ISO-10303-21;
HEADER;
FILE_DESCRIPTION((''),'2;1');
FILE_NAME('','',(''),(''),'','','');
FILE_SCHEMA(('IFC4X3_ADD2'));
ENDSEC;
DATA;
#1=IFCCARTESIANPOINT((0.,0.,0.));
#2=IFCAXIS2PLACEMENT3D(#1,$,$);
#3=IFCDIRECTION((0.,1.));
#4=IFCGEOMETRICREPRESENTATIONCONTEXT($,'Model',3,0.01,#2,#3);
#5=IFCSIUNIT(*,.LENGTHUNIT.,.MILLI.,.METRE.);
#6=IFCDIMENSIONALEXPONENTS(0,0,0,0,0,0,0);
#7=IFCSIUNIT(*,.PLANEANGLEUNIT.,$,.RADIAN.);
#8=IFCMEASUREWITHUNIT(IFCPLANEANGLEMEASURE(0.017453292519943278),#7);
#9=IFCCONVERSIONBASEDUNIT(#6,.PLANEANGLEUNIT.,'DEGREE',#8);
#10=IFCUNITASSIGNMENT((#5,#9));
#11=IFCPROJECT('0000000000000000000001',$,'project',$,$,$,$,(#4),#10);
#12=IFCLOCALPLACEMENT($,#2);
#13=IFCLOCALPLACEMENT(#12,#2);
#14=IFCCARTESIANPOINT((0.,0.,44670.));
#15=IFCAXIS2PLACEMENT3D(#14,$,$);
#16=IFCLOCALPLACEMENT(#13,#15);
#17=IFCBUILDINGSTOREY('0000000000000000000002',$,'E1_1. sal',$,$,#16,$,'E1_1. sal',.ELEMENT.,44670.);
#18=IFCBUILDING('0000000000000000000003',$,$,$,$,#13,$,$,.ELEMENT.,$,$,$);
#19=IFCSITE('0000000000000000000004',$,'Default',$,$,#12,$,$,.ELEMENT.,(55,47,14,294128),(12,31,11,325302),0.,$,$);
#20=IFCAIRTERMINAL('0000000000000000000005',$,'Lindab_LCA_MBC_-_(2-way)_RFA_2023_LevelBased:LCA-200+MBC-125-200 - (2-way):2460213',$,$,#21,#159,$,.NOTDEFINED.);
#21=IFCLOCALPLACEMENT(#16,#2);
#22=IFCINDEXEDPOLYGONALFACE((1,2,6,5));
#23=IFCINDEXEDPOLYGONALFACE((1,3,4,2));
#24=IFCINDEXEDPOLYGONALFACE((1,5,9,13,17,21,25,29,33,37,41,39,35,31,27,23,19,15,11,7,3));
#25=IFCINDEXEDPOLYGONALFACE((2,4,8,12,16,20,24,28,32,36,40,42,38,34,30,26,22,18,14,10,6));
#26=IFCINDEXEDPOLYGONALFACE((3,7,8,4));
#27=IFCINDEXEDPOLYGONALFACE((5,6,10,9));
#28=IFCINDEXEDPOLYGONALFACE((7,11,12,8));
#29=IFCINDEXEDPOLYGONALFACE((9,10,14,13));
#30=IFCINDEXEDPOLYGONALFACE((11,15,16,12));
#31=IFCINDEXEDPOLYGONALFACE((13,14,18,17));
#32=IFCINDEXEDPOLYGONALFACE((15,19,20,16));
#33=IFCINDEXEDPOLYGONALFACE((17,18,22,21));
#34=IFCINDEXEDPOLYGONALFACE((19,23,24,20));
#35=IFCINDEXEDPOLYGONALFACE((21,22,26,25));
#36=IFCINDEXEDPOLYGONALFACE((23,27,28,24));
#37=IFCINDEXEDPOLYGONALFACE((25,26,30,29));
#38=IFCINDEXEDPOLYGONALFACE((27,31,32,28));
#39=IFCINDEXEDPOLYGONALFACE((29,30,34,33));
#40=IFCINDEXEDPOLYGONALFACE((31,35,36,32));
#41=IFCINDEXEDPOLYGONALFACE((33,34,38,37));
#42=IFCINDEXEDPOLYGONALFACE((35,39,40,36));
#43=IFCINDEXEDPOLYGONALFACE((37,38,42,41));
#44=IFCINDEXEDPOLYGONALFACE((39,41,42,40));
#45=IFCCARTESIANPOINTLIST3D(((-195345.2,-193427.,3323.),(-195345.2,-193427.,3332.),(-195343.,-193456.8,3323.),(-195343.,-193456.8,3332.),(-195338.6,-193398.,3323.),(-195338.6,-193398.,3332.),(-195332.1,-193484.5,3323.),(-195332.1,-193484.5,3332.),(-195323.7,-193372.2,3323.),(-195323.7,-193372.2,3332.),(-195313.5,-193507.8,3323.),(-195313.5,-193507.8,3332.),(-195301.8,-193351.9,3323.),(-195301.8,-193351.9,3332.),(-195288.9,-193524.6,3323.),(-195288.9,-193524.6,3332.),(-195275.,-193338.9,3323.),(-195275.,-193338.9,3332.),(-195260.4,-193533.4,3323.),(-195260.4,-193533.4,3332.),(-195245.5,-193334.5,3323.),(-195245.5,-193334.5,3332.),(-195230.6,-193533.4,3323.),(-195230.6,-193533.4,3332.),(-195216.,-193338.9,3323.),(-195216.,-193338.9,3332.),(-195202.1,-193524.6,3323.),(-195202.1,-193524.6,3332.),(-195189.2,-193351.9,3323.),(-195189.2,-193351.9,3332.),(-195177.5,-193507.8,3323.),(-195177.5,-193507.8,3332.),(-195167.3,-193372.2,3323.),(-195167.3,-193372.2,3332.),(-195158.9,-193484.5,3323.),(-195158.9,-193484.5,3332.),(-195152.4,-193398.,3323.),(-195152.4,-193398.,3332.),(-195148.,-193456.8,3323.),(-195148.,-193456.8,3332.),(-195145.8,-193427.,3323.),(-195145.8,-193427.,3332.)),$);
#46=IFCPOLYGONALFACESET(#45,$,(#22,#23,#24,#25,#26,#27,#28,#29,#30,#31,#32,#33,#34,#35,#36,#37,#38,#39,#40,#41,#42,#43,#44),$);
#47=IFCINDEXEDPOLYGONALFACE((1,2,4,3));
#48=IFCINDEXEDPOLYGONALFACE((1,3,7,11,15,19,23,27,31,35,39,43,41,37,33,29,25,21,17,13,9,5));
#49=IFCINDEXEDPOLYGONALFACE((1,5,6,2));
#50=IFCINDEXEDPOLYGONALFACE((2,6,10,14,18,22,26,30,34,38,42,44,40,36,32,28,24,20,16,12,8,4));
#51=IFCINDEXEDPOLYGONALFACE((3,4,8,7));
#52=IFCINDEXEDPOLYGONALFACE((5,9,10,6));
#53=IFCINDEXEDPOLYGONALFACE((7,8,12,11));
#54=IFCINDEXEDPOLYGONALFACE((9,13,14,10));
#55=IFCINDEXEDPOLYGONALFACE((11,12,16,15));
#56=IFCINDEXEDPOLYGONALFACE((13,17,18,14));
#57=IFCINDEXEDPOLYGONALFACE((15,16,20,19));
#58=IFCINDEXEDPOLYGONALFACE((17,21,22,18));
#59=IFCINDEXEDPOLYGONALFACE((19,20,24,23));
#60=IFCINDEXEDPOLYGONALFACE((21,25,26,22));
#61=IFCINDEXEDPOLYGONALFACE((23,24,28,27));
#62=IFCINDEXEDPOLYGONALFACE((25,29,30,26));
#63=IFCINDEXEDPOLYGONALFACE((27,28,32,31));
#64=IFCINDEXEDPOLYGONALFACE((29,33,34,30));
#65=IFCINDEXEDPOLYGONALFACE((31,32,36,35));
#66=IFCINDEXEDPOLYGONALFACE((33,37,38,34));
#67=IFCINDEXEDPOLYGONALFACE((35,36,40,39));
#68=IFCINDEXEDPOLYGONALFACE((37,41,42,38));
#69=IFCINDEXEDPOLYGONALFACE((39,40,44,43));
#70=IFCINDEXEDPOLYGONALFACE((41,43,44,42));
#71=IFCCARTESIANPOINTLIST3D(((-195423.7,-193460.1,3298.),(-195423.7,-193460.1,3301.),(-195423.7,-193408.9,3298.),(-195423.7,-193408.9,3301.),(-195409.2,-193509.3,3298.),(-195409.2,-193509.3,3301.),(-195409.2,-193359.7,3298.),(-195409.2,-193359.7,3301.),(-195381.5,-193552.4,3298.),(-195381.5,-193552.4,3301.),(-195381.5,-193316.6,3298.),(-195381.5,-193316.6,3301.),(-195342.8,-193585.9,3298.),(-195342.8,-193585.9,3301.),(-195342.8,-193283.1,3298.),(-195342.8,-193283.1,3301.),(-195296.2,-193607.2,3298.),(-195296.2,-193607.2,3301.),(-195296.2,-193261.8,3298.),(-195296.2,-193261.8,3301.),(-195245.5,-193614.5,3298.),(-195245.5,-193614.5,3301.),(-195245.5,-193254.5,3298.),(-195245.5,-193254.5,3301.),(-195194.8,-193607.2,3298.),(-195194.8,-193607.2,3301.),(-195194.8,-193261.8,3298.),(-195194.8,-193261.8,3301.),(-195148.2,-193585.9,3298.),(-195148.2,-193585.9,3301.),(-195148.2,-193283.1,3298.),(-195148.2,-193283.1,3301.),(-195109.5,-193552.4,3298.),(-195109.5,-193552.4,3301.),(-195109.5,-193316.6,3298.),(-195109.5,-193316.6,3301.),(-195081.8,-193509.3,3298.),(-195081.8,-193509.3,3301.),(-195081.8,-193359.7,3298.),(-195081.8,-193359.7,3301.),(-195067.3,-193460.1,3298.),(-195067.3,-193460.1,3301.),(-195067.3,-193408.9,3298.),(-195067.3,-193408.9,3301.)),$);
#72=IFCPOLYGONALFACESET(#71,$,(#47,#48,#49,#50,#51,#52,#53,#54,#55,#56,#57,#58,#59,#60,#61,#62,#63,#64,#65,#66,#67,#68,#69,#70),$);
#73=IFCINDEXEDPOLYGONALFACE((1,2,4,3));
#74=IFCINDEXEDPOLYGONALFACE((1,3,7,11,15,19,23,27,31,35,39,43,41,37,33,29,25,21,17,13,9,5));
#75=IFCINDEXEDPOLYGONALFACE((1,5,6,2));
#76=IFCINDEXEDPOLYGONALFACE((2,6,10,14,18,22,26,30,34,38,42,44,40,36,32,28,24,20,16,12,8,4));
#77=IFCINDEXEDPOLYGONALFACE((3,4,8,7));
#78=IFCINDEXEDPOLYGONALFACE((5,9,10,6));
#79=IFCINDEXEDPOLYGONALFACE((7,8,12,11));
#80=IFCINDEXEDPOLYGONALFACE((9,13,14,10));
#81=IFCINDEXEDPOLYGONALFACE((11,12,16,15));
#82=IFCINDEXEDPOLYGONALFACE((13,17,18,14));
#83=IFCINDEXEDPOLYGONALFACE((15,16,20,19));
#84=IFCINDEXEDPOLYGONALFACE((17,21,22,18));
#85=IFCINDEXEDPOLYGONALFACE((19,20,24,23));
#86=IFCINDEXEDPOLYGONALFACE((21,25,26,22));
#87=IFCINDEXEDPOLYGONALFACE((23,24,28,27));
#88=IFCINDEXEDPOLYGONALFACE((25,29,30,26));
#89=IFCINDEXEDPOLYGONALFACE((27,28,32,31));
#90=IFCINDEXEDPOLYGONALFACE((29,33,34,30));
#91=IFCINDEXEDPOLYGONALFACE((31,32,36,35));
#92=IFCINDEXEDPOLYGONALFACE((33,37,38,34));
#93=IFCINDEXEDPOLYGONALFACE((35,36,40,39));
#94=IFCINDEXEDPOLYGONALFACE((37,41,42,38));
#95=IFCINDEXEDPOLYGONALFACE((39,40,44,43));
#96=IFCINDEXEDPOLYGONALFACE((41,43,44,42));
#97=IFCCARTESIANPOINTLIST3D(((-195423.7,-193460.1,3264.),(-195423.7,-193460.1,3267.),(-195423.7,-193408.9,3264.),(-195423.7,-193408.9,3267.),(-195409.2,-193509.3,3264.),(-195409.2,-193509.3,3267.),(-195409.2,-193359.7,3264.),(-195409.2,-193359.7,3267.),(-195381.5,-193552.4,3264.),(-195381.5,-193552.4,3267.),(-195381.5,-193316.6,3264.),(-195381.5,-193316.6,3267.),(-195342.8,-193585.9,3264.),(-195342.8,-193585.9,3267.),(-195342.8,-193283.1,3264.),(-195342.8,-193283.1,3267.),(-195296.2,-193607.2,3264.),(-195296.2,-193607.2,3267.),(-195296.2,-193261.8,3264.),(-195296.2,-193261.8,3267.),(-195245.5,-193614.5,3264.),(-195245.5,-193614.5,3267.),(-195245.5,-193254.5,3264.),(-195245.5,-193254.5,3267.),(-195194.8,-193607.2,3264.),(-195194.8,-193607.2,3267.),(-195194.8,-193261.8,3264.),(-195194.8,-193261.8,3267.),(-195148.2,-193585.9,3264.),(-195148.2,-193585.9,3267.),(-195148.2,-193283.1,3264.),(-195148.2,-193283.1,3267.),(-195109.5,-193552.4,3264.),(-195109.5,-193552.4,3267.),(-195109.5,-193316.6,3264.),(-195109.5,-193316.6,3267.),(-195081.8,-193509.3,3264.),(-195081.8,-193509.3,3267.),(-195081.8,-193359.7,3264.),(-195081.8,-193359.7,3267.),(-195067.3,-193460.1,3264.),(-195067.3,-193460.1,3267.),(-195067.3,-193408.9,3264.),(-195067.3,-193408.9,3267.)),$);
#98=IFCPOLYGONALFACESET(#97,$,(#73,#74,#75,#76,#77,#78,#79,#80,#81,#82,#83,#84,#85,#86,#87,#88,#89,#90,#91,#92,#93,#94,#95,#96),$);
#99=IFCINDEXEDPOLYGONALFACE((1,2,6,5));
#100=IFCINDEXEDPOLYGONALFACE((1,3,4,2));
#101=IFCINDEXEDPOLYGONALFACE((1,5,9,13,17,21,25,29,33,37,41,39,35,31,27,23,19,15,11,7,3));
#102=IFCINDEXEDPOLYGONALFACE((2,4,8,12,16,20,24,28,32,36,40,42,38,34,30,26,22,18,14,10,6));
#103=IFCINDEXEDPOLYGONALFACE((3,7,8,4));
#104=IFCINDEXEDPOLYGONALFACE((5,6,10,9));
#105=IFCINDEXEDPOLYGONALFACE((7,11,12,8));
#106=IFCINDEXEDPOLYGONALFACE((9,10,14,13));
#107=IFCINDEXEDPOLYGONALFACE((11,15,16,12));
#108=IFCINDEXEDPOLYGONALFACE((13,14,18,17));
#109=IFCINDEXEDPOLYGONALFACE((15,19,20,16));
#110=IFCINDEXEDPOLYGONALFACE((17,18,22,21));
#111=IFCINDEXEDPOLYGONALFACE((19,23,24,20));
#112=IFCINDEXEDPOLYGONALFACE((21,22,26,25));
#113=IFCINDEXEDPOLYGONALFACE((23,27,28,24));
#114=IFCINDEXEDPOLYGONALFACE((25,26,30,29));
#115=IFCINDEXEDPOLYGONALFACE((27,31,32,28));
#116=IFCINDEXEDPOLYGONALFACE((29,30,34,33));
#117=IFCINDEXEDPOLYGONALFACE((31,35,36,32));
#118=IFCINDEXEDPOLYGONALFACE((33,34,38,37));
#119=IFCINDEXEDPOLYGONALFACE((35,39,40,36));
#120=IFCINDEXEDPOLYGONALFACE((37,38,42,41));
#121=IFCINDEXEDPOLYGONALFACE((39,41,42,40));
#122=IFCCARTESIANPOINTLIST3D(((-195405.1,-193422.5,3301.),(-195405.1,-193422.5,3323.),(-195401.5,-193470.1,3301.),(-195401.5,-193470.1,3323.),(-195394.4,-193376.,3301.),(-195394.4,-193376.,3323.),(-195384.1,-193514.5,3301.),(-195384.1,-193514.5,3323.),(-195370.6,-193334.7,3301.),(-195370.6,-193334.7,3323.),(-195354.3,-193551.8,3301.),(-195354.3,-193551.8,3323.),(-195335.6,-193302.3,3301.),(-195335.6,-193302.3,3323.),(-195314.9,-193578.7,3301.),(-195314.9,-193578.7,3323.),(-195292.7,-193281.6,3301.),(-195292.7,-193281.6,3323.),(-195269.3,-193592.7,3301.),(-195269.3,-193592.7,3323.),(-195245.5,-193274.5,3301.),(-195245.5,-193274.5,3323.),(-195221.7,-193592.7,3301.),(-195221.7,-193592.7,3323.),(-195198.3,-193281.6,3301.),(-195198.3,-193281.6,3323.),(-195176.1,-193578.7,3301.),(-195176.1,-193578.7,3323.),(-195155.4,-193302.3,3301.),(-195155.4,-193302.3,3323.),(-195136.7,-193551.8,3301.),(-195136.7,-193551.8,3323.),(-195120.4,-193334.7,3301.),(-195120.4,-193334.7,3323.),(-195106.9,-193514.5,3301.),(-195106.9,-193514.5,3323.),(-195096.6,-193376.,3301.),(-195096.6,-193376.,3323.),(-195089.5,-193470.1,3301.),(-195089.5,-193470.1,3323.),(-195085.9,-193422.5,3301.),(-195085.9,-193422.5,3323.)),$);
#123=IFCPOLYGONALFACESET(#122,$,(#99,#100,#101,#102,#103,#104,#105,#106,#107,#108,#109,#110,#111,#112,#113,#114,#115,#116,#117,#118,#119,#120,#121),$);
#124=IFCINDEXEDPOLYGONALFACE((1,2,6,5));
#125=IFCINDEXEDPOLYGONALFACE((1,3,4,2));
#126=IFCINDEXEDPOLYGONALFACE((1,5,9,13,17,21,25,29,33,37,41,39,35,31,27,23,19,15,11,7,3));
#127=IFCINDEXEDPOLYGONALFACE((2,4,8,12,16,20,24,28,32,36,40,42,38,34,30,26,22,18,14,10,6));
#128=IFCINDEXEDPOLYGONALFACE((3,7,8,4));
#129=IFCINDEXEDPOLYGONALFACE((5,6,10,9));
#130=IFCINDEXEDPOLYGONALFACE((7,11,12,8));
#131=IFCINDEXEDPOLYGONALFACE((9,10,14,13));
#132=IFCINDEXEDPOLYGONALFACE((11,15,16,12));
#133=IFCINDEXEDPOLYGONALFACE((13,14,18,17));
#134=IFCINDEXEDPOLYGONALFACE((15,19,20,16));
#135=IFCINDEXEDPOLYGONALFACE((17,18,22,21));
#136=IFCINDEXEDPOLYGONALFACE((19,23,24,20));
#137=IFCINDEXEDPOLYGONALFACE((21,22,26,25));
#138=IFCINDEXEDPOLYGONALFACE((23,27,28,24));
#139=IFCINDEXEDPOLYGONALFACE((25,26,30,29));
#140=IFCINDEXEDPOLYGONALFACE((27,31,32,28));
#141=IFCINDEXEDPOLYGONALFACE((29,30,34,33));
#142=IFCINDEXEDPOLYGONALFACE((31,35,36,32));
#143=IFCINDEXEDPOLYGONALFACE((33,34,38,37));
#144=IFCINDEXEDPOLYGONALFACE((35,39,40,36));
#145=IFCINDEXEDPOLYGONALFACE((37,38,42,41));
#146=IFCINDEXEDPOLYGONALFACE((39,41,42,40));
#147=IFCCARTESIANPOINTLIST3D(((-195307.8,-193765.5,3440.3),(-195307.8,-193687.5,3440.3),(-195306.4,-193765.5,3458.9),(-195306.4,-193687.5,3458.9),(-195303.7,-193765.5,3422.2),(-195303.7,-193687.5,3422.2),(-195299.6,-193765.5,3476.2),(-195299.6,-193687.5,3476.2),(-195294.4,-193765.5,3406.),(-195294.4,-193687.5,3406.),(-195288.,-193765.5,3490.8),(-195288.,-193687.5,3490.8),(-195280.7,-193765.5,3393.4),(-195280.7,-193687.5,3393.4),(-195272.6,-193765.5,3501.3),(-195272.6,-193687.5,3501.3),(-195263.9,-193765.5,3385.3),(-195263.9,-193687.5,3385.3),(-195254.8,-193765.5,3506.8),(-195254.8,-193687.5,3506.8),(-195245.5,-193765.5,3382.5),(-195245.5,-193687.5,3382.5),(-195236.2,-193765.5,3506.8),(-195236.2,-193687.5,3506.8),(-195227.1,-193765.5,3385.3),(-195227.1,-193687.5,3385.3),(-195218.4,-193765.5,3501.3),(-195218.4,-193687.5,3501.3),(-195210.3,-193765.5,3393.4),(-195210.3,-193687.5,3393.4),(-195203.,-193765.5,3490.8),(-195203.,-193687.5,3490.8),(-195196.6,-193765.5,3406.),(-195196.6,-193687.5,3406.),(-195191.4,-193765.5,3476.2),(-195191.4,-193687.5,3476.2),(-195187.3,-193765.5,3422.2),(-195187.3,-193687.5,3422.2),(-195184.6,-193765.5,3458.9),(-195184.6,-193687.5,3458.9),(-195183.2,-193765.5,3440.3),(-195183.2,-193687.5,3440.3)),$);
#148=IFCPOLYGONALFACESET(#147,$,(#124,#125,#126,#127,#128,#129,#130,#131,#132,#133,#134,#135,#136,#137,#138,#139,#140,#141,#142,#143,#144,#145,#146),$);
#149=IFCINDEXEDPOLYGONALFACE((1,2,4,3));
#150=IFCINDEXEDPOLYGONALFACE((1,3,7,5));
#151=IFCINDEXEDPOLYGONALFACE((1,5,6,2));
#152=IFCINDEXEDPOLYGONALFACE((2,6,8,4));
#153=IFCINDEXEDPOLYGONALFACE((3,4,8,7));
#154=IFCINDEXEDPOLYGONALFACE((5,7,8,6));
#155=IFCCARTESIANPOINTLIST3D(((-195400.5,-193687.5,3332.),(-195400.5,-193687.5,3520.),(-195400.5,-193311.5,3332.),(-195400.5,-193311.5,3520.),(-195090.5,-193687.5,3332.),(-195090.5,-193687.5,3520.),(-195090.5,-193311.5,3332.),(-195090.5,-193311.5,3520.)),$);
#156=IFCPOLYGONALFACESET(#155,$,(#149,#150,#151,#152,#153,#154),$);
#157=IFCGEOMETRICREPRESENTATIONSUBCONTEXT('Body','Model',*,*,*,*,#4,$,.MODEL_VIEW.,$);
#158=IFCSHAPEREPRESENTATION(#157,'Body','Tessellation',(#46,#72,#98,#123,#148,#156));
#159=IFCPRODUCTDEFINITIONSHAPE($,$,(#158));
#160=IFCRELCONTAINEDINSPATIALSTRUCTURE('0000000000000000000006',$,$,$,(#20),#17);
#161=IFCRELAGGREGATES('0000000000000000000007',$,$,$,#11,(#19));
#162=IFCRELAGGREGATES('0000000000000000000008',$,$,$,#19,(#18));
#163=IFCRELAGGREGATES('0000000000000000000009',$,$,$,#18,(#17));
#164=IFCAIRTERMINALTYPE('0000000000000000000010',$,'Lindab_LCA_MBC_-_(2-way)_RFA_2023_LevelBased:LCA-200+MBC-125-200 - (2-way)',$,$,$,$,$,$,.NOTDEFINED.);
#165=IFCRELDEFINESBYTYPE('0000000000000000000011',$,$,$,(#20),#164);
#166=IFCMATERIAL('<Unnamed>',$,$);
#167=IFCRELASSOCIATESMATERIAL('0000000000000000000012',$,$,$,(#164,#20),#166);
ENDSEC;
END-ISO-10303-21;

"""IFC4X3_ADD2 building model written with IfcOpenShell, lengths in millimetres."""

from ifc_helpers import new_model, entity, si_unit, converted_unit, direction, frame, frame_2d, origin, origin_2d_with_axis, place, context, subcontext, project, spatial, rectangle, circle, extrude, source, transform, mapped, material, type_object, type_shapes, element, save


model = new_model("IFC4X3_ADD2")

# Units and contexts
model_context = context("Model", 3, precision=0.01, world=origin(), true_north=direction((0.0, 1.0)))
body_context = subcontext(model_context, "Body", "Model", "MODEL_VIEW")
ifc_project = project(units=[si_unit("LENGTHUNIT", "METRE", prefix="MILLI"), converted_unit("PLANEANGLEUNIT", "DEGREE", entity("IfcPlaneAngleMeasure", 0.017453292519943278), si_unit("PLANEANGLEUNIT", "RADIAN"), dimensions=[0, 0, 0, 0, 0, 0, 0])], contexts=[model_context])

# Site, building, storey
site_placement = place(None, origin())
site = spatial("IfcSite", under=ifc_project, at=site_placement, Name="Default", CompositionType="ELEMENT", RefLatitude=(55, 47, 14, 294128), RefLongitude=(12, 31, 11, 325302), RefElevation=0.0)
building_placement = place(site_placement, origin())
building = spatial("IfcBuilding", under=site, at=building_placement, CompositionType="ELEMENT")
storey_placement = place(building_placement, frame((0.0, 0.0, 44670.0)))
storey = spatial("IfcBuildingStorey", under=building, at=storey_placement, Name="E1_1. sal", LongName="E1_1. sal", CompositionType="ELEMENT", Elevation=44670.0)

# Air terminal
ifc_material_1 = material(Name="<Unnamed>")
air_terminal_type = type_object("IfcAirTerminalType", Name="Lindab_LCA_MBC_-_(2-way)_RFA_2023_LevelBased:LCA-200+MBC-125-200 - (2-way)", PredefinedType="NOTDEFINED", material=ifc_material_1)
shared_shape_1 = source(origin(), body_context, "Body", "SweptSolid", [
    extrude(circle(Radius=100.0, at=frame_2d((0.0, 0.0), x_axis=(1.0, 0.0))), frame((0.0, 0.0, 22.0)), (0.0, 0.0, 1.0), 9.0),
    extrude(circle(Radius=180.0, at=frame_2d((0.0, 0.0), x_axis=(1.0, 0.0))), frame((0.0, 0.0, -3.0)), (0.0, 0.0, 1.0), 3.0),
    extrude(circle(Radius=180.0, at=frame_2d((0.0, 0.0), x_axis=(1.0, 0.0))), frame((0.0, 0.0, -37.0)), (0.0, 0.0, 1.0), 3.0),
    extrude(circle(Radius=160.0, at=frame_2d((0.0, 0.0), x_axis=(1.0, 0.0))), origin(), (0.0, 0.0, 1.0), 22.0),
    extrude(circle(Radius=62.5, at=frame_2d((0.0, 0.0), x_axis=(1.0, 0.0))), frame((-331.0, 0.0, 144.0), z_axis=(1.0, 0.0, 0.0), x_axis=(0.0, 0.0, -1.0)), (0.0, 0.0, 1.0), 78.0),
    extrude(rectangle(XDim=310.0, YDim=376.0, at=origin_2d_with_axis()), frame((-65.0, 0.0, 31.0), z_axis=(0.0, 0.0, 1.0), x_axis=(0.0, -1.0, 0.0)), (0.0, 0.0, 1.0), 188.0),
])
type_shapes(air_terminal_type, [shared_shape_1])
for number, where, z_axis, x_axis, name in (
    (1, (-195245.5, -193434.5, 3301.0), (0.0, 0.0, 1.0), (0.0, 1.0, 0.0), "Lindab_LCA_MBC_-_(2-way)_RFA_2023_LevelBased:LCA-200+MBC-125-200 - (2-way):2460213"),
):
    element("IfcAirTerminal", number, at=place(storey_placement, frame(where, z_axis=z_axis, x_axis=x_axis)), inside=storey, type_object=air_terminal_type, material=ifc_material_1, Name=name, PredefinedType="NOTDEFINED", context=body_context, shape_type="MappedRepresentation", body=[
        mapped(shared_shape_1, transform((0.0, 0.0, 0.0), scale=1.0)),
    ])

save(model, "model.ifc")
